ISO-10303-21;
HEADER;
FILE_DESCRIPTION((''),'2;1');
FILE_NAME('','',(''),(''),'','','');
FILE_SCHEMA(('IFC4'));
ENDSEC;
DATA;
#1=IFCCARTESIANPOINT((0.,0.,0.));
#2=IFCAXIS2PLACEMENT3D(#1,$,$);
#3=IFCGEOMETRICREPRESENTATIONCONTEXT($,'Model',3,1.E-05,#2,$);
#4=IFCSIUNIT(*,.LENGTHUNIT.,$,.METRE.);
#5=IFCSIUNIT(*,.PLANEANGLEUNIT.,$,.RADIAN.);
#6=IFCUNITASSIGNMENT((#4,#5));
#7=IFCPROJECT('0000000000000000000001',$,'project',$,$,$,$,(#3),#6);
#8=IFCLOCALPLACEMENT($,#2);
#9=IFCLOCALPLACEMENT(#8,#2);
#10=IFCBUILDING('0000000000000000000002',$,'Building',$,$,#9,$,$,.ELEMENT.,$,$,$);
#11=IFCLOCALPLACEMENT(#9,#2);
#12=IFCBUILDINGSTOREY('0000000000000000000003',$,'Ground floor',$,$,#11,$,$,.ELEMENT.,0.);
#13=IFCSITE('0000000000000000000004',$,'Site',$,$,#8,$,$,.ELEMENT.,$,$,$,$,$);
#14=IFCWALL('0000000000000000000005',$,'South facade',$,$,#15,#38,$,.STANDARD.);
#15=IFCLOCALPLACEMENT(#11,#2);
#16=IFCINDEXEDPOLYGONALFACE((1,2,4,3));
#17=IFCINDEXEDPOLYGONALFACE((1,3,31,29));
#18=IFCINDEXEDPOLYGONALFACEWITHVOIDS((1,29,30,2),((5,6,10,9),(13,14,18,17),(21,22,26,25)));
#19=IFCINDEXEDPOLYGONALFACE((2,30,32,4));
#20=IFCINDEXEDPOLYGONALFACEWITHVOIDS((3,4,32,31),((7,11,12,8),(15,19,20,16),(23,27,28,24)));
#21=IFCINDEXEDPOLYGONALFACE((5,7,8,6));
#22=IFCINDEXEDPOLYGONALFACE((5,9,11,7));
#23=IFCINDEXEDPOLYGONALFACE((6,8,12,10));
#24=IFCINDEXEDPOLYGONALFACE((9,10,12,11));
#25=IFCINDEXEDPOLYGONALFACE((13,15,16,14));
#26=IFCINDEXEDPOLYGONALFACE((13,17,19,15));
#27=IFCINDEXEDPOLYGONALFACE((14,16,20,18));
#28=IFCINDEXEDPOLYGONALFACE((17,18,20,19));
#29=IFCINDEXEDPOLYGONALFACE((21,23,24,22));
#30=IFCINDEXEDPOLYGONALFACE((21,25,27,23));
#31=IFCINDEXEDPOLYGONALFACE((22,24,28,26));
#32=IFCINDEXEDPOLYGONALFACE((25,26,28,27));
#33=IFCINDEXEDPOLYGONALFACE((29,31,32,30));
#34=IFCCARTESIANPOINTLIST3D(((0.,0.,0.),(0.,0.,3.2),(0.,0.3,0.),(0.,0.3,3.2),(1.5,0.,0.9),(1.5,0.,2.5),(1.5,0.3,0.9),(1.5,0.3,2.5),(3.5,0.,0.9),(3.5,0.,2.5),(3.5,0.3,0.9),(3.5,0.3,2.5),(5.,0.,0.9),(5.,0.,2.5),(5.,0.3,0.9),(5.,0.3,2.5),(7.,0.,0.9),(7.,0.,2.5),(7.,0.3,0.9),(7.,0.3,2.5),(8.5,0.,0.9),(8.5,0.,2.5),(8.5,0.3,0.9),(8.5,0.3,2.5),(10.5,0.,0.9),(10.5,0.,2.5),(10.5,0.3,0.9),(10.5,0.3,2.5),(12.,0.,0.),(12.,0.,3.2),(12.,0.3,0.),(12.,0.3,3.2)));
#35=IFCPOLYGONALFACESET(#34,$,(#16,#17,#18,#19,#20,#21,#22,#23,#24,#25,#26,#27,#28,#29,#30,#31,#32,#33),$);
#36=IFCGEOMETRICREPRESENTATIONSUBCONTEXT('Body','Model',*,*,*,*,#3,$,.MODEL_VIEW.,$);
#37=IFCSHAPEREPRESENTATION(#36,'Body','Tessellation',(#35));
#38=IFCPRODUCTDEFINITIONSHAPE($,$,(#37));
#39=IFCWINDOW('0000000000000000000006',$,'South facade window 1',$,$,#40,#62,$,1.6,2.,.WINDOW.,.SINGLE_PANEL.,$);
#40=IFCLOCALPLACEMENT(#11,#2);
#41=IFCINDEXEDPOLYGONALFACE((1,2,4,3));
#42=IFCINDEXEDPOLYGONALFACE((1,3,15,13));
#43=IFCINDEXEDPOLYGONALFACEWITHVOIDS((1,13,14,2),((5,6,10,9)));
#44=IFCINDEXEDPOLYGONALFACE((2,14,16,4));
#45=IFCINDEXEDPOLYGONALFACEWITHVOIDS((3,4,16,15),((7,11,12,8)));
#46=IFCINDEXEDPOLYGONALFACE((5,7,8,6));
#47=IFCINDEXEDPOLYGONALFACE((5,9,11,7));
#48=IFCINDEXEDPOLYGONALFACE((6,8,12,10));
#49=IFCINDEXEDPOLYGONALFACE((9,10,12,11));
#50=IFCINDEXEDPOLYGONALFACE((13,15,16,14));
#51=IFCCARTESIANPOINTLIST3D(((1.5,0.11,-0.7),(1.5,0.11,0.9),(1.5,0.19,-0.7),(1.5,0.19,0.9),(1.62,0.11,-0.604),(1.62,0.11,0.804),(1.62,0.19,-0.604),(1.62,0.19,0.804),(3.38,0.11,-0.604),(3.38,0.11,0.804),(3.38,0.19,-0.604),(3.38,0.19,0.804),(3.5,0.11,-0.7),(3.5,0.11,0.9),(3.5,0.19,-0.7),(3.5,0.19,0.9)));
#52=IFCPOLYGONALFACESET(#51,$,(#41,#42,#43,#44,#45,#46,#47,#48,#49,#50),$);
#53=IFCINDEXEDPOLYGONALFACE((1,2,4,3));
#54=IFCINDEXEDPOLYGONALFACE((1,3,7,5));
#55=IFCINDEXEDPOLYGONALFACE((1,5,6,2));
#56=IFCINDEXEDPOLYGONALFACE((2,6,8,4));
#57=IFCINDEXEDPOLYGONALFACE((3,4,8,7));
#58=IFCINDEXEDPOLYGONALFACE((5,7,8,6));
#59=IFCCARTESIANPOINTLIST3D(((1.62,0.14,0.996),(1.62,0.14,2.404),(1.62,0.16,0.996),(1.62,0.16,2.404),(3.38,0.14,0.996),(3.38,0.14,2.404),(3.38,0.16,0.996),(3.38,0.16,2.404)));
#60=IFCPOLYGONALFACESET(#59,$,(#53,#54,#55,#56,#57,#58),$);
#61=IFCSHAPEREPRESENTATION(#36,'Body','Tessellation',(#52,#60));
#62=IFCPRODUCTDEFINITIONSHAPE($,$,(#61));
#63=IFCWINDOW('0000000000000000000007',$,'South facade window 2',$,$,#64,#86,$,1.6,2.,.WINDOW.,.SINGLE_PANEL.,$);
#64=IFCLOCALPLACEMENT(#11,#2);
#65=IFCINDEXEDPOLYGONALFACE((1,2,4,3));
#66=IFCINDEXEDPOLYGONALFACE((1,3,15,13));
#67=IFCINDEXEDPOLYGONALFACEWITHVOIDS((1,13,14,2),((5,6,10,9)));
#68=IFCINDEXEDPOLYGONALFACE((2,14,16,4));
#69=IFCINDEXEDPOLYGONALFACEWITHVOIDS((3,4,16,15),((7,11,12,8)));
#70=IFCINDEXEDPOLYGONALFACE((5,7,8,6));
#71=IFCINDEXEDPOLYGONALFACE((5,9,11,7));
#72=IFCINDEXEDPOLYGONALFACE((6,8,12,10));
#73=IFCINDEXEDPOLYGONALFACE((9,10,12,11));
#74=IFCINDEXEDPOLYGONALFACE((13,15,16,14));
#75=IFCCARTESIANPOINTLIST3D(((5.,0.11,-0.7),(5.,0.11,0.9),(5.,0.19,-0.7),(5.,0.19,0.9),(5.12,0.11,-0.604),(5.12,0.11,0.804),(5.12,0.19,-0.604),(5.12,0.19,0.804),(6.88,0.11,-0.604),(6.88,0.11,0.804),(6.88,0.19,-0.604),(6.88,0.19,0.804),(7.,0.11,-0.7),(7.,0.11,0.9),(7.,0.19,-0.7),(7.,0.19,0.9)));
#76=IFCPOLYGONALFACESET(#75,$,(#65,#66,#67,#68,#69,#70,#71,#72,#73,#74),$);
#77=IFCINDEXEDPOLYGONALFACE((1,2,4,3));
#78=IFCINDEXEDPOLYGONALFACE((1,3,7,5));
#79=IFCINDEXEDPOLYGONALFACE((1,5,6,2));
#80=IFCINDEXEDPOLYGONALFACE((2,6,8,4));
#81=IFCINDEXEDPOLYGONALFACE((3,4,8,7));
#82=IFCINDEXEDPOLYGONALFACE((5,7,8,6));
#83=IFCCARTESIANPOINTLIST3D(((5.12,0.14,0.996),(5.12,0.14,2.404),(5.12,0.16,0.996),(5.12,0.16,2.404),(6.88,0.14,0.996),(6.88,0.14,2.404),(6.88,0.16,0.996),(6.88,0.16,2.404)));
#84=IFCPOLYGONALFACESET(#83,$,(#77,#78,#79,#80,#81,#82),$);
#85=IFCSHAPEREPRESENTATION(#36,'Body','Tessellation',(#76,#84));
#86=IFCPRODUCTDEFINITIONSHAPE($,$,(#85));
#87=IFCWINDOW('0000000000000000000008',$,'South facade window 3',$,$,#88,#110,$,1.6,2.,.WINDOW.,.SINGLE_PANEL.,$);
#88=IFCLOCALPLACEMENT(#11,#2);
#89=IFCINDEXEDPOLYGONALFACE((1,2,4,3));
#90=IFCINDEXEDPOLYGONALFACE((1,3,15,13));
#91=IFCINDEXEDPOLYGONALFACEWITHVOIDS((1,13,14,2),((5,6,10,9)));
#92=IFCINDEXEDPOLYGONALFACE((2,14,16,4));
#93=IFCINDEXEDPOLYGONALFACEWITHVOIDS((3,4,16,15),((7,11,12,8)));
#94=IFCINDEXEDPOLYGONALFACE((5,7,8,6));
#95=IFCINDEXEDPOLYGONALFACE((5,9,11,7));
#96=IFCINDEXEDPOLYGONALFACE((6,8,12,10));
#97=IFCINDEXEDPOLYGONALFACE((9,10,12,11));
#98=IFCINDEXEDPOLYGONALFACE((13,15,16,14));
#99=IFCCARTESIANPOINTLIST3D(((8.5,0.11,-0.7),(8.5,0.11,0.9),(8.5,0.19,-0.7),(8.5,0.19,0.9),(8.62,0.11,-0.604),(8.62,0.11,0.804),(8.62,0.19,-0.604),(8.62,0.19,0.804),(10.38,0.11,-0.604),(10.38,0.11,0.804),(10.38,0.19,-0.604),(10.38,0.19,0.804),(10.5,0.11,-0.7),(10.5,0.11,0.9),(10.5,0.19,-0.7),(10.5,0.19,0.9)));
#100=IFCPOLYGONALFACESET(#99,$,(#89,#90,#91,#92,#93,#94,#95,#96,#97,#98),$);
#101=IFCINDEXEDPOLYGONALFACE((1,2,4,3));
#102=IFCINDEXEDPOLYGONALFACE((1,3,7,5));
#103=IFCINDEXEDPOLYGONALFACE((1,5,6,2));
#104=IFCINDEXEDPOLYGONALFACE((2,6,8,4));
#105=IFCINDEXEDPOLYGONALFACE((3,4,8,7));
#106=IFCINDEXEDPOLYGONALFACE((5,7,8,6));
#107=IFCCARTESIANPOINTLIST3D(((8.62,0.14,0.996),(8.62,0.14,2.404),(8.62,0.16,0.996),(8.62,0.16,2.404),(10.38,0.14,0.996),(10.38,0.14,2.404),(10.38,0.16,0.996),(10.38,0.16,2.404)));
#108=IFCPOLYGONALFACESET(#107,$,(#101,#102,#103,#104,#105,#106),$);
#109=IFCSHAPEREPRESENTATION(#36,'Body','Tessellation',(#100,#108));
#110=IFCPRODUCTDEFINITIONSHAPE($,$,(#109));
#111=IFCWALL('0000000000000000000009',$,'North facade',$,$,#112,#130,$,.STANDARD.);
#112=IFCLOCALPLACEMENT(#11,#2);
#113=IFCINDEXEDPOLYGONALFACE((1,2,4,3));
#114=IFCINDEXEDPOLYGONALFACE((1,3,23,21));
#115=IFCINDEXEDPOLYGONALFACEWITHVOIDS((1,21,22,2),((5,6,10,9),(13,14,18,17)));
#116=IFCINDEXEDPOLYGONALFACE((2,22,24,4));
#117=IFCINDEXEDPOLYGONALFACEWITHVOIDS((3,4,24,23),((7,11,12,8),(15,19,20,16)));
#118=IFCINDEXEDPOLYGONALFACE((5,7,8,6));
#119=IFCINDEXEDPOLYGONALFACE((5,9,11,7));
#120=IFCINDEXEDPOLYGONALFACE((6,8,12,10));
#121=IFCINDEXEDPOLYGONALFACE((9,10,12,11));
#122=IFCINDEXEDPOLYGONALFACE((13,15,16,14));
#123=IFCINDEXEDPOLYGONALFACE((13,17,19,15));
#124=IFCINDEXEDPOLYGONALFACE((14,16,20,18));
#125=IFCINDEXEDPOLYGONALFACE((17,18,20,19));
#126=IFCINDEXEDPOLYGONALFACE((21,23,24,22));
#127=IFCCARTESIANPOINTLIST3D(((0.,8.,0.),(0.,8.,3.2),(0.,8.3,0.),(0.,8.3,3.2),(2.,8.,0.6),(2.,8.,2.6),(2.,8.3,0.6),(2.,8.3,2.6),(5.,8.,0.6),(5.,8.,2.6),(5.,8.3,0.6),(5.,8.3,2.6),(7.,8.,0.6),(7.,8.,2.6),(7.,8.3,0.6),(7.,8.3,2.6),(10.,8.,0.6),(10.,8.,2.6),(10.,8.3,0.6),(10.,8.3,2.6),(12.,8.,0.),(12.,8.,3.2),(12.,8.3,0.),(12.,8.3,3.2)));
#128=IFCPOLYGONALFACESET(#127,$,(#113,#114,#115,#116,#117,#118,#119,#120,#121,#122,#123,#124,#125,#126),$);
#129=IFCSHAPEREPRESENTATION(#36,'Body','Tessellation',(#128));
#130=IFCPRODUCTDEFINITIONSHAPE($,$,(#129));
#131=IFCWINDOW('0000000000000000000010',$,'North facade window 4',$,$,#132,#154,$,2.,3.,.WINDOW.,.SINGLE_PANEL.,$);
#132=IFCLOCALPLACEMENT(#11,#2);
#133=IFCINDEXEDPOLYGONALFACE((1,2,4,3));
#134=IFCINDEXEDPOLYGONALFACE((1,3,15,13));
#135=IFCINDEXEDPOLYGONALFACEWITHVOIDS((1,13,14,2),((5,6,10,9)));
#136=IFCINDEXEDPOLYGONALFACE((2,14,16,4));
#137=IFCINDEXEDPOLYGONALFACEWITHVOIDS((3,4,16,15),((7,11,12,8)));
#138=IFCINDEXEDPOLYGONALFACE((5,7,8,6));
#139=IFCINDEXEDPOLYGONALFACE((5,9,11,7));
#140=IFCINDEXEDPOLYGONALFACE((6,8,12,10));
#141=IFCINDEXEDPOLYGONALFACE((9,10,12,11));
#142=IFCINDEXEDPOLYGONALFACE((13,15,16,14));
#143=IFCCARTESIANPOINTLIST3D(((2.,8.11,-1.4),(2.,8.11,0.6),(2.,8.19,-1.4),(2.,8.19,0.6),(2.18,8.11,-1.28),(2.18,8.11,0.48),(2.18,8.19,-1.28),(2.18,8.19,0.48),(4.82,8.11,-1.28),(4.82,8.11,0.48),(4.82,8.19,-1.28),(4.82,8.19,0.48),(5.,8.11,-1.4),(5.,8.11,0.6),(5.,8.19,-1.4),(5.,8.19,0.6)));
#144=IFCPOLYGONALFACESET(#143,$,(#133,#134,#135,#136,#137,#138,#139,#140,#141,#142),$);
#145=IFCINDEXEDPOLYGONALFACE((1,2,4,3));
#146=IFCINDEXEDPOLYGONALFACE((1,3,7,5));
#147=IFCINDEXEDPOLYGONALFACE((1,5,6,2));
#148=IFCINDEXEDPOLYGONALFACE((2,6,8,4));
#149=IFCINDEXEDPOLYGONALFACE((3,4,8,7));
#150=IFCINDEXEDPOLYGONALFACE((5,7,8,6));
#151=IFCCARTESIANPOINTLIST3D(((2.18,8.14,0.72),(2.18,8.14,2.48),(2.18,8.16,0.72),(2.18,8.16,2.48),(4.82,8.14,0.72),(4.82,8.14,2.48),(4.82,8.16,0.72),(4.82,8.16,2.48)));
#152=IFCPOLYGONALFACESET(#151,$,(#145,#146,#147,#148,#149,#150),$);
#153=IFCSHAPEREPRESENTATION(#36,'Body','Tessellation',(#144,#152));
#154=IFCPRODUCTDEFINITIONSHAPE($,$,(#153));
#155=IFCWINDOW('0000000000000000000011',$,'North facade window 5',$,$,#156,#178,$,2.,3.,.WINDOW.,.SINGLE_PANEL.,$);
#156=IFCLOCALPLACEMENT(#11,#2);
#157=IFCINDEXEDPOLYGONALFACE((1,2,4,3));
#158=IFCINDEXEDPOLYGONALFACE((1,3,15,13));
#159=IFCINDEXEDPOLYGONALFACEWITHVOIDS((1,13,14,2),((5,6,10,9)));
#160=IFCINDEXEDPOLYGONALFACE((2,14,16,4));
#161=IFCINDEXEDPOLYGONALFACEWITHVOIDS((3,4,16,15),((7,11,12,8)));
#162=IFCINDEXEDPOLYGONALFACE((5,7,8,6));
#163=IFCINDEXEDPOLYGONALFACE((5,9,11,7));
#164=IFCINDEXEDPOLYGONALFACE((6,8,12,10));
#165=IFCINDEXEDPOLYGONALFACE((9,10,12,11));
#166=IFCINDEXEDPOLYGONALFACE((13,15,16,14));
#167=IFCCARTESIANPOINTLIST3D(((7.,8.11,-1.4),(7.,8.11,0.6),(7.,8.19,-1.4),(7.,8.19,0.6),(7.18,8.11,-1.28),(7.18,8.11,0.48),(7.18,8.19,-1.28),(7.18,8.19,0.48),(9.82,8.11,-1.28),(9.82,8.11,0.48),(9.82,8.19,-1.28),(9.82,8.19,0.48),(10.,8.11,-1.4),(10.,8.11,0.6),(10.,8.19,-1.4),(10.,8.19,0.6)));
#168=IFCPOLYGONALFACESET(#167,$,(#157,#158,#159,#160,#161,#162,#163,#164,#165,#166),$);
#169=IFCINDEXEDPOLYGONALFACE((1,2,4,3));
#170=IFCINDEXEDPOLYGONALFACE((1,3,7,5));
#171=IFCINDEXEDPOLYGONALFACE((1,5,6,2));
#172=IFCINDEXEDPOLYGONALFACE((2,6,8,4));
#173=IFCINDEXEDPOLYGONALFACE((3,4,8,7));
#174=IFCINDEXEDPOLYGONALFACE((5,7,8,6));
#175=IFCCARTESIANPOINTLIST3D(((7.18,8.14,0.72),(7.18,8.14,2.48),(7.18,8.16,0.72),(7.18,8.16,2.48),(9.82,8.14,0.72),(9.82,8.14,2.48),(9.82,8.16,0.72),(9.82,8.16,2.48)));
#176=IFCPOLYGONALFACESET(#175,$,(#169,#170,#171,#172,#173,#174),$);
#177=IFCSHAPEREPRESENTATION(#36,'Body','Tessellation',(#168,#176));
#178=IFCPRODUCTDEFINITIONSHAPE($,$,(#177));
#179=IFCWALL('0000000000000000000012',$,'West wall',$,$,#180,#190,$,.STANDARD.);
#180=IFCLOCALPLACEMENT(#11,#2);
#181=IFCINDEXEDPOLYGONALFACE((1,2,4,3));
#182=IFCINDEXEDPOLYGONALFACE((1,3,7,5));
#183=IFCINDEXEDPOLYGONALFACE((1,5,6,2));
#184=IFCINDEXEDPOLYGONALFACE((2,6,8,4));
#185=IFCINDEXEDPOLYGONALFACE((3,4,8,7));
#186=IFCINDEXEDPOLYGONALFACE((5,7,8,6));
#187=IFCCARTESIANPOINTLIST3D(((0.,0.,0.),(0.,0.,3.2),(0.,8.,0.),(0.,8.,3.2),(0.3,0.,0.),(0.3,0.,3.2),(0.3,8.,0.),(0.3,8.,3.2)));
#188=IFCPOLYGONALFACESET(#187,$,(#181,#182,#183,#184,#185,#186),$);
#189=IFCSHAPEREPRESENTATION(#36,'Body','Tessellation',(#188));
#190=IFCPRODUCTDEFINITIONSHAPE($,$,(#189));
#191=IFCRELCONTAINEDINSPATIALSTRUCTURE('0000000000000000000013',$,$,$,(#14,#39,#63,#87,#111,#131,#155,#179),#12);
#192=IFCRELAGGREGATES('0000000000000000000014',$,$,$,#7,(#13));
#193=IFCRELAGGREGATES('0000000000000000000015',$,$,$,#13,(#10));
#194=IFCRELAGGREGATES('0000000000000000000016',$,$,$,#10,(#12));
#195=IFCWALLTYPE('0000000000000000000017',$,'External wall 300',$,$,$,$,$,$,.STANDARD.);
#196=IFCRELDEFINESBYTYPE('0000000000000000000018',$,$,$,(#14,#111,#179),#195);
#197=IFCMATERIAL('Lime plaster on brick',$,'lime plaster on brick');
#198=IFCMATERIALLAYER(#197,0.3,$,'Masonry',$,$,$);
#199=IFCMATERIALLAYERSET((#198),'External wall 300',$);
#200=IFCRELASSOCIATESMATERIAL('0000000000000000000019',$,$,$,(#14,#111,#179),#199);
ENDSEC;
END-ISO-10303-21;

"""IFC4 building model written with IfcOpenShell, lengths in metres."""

from ifc_helpers import new_model, si_unit, frame, frame_2d, origin, origin_with_axes, place, context, subcontext, project, spatial, polyline, rectangle, outline, extrude, source, transform, mapped, material, layer, layer_set, layer_usage, type_object, element, fill, save


model = new_model("IFC4")

# Units and contexts
model_context = context("Model", 3, precision=1e-05, world=origin())
body_context = subcontext(model_context, "Body", "Model", "MODEL_VIEW")
ifc_project = project(units=[si_unit("LENGTHUNIT", "METRE"), si_unit("PLANEANGLEUNIT", "RADIAN")], contexts=[model_context])

# Site, building, storey
site_placement = place(None, origin())
site = spatial("IfcSite", under=ifc_project, at=site_placement, Name="Site", CompositionType="ELEMENT")
building_placement = place(site_placement, origin())
building = spatial("IfcBuilding", under=site, at=building_placement, Name="Building", CompositionType="ELEMENT")
storey_placement = place(building_placement, origin())
storey = spatial("IfcBuildingStorey", under=building, at=storey_placement, Name="Ground floor", CompositionType="ELEMENT", Elevation=0.0)

# Walls, openings, windows
ifc_material_1 = material(Name="Lime plaster on brick", Category="lime plaster on brick")
ifc_layer = layer(ifc_material_1, 0.3, Name="Masonry")
ifc_layer_set = layer_set([ifc_layer], Name="External wall 300")
ifc_layer_usage = layer_usage(ifc_layer_set, "AXIS2", "POSITIVE", 0.0)
wall_type = type_object("IfcWallType", Name="External wall 300", PredefinedType="STANDARD")
wall_1_placement = place(storey_placement, origin_with_axes())
wall_1 = element("IfcWall", 1, at=wall_1_placement, inside=storey, type_object=wall_type, material=ifc_layer_usage, Name="South facade", PredefinedType="STANDARD", context=body_context, shape_type="SweptSolid", body=[
    extrude(rectangle(XDim=12.0, YDim=0.3, at=frame_2d((6.0, 0.15))), origin(), (0.0, 0.0, 1.0), 3.2),
])
opening_1_placement = place(wall_1_placement, frame((1.5, -0.1, 0.9)))
opening_1 = element("IfcOpeningElement", 2, at=opening_1_placement, cuts=wall_1, PredefinedType="OPENING", context=body_context, shape_type="SweptSolid", body=[
    extrude(rectangle(XDim=2.0, YDim=0.5, at=frame_2d((1.0, 0.25))), origin(), (0.0, 0.0, 1.0), 1.6),
])
opening_2_placement = place(wall_1_placement, frame((5.0, -0.1, 0.9)))
opening_2 = element("IfcOpeningElement", 3, at=opening_2_placement, cuts=wall_1, PredefinedType="OPENING", context=body_context, shape_type="SweptSolid", body=[
    extrude(rectangle(XDim=2.0, YDim=0.5, at=frame_2d((1.0, 0.25))), origin(), (0.0, 0.0, 1.0), 1.6),
])
opening_3_placement = place(wall_1_placement, frame((8.5, -0.1, 0.9)))
opening_3 = element("IfcOpeningElement", 4, at=opening_3_placement, cuts=wall_1, PredefinedType="OPENING", context=body_context, shape_type="SweptSolid", body=[
    extrude(rectangle(XDim=2.0, YDim=0.5, at=frame_2d((1.0, 0.25))), origin(), (0.0, 0.0, 1.0), 1.6),
])
shared_shape_1 = source(origin(), body_context, "Body", "SweptSolid", [
    extrude(outline(polyline([(0.0, 0.0), (1.0, 0.0), (1.0, 1.0), (0.0, 1.0), (0.0, 0.0)]), holes=[polyline([(0.06, 0.06), (0.94, 0.06), (0.94, 0.94), (0.06, 0.94), (0.06, 0.06)])]), frame((0.0, 0.11, 0.0), z_axis=(0.0, 1.0, 0.0), x_axis=(1.0, 0.0, 0.0)), (0.0, 0.0, 1.0), 0.08),
    extrude(rectangle(XDim=0.88, YDim=0.02, at=frame_2d((0.44, 0.01))), frame((0.06, 0.14, 0.06)), (0.0, 0.0, 1.0), 0.88),
])
window_1_placement = place(wall_1_placement, frame((1.5, 0.0, 0.9)))
window_1 = element("IfcWindow", 5, at=window_1_placement, inside=storey, Name="South facade window 1", OverallHeight=1.6, OverallWidth=2.0, PartitioningType="SINGLE_PANEL", PredefinedType="WINDOW", context=body_context, shape_type="MappedRepresentation", body=[
    mapped(shared_shape_1, transform((0.0, 0.0, 0.0), scale=2.0, scale2=1.0, scale3=1.6, uniform=False)),
])
fill(opening_1, window_1)
window_2_placement = place(wall_1_placement, frame((5.0, 0.0, 0.9)))
window_2 = element("IfcWindow", 6, at=window_2_placement, inside=storey, Name="South facade window 2", OverallHeight=1.6, OverallWidth=2.0, PartitioningType="SINGLE_PANEL", PredefinedType="WINDOW", context=body_context, shape_type="MappedRepresentation", body=[
    mapped(shared_shape_1, transform((0.0, 0.0, 0.0), scale=2.0, scale2=1.0, scale3=1.6, uniform=False)),
])
fill(opening_2, window_2)
window_3_placement = place(wall_1_placement, frame((8.5, 0.0, 0.9)))
window_3 = element("IfcWindow", 7, at=window_3_placement, inside=storey, Name="South facade window 3", OverallHeight=1.6, OverallWidth=2.0, PartitioningType="SINGLE_PANEL", PredefinedType="WINDOW", context=body_context, shape_type="MappedRepresentation", body=[
    mapped(shared_shape_1, transform((0.0, 0.0, 0.0), scale=2.0, scale2=1.0, scale3=1.6, uniform=False)),
])
fill(opening_3, window_3)
wall_2_placement = place(storey_placement, frame((0.0, 8.0, 0.0), z_axis=(0.0, 0.0, 1.0), x_axis=(1.0, 0.0, 0.0)))
wall_2 = element("IfcWall", 8, at=wall_2_placement, inside=storey, type_object=wall_type, material=ifc_layer_usage, Name="North facade", PredefinedType="STANDARD", context=body_context, shape_type="SweptSolid", body=[
    extrude(rectangle(XDim=12.0, YDim=0.3, at=frame_2d((6.0, 0.15))), origin(), (0.0, 0.0, 1.0), 3.2),
])
opening_4_placement = place(wall_2_placement, frame((2.0, -0.1, 0.6)))
opening_4 = element("IfcOpeningElement", 9, at=opening_4_placement, cuts=wall_2, PredefinedType="OPENING", context=body_context, shape_type="SweptSolid", body=[
    extrude(rectangle(XDim=3.0, YDim=0.5, at=frame_2d((1.5, 0.25))), origin(), (0.0, 0.0, 1.0), 2.0),
])
opening_5_placement = place(wall_2_placement, frame((7.0, -0.1, 0.6)))
opening_5 = element("IfcOpeningElement", 10, at=opening_5_placement, cuts=wall_2, PredefinedType="OPENING", context=body_context, shape_type="SweptSolid", body=[
    extrude(rectangle(XDim=3.0, YDim=0.5, at=frame_2d((1.5, 0.25))), origin(), (0.0, 0.0, 1.0), 2.0),
])
window_4_placement = place(wall_2_placement, frame((2.0, 0.0, 0.6)))
window_4 = element("IfcWindow", 11, at=window_4_placement, inside=storey, Name="North facade window 4", OverallHeight=2.0, OverallWidth=3.0, PartitioningType="SINGLE_PANEL", PredefinedType="WINDOW", context=body_context, shape_type="MappedRepresentation", body=[
    mapped(shared_shape_1, transform((0.0, 0.0, 0.0), scale=3.0, scale2=1.0, scale3=2.0, uniform=False)),
])
fill(opening_4, window_4)
window_5_placement = place(wall_2_placement, frame((7.0, 0.0, 0.6)))
window_5 = element("IfcWindow", 12, at=window_5_placement, inside=storey, Name="North facade window 5", OverallHeight=2.0, OverallWidth=3.0, PartitioningType="SINGLE_PANEL", PredefinedType="WINDOW", context=body_context, shape_type="MappedRepresentation", body=[
    mapped(shared_shape_1, transform((0.0, 0.0, 0.0), scale=3.0, scale2=1.0, scale3=2.0, uniform=False)),
])
fill(opening_5, window_5)

# Wall
wall_3_placement = place(storey_placement, frame((0.3, 0.0, 0.0), z_axis=(0.0, 0.0, 1.0), x_axis=(0.0, 1.0, 0.0)))
element("IfcWall", 13, at=wall_3_placement, inside=storey, type_object=wall_type, material=ifc_layer_usage, Name="West wall", PredefinedType="STANDARD", context=body_context, shape_type="SweptSolid", body=[
    extrude(rectangle(XDim=8.0, YDim=0.3, at=frame_2d((4.0, 0.15))), origin(), (0.0, 0.0, 1.0), 3.2),
])

save(model, "model.ifc")
